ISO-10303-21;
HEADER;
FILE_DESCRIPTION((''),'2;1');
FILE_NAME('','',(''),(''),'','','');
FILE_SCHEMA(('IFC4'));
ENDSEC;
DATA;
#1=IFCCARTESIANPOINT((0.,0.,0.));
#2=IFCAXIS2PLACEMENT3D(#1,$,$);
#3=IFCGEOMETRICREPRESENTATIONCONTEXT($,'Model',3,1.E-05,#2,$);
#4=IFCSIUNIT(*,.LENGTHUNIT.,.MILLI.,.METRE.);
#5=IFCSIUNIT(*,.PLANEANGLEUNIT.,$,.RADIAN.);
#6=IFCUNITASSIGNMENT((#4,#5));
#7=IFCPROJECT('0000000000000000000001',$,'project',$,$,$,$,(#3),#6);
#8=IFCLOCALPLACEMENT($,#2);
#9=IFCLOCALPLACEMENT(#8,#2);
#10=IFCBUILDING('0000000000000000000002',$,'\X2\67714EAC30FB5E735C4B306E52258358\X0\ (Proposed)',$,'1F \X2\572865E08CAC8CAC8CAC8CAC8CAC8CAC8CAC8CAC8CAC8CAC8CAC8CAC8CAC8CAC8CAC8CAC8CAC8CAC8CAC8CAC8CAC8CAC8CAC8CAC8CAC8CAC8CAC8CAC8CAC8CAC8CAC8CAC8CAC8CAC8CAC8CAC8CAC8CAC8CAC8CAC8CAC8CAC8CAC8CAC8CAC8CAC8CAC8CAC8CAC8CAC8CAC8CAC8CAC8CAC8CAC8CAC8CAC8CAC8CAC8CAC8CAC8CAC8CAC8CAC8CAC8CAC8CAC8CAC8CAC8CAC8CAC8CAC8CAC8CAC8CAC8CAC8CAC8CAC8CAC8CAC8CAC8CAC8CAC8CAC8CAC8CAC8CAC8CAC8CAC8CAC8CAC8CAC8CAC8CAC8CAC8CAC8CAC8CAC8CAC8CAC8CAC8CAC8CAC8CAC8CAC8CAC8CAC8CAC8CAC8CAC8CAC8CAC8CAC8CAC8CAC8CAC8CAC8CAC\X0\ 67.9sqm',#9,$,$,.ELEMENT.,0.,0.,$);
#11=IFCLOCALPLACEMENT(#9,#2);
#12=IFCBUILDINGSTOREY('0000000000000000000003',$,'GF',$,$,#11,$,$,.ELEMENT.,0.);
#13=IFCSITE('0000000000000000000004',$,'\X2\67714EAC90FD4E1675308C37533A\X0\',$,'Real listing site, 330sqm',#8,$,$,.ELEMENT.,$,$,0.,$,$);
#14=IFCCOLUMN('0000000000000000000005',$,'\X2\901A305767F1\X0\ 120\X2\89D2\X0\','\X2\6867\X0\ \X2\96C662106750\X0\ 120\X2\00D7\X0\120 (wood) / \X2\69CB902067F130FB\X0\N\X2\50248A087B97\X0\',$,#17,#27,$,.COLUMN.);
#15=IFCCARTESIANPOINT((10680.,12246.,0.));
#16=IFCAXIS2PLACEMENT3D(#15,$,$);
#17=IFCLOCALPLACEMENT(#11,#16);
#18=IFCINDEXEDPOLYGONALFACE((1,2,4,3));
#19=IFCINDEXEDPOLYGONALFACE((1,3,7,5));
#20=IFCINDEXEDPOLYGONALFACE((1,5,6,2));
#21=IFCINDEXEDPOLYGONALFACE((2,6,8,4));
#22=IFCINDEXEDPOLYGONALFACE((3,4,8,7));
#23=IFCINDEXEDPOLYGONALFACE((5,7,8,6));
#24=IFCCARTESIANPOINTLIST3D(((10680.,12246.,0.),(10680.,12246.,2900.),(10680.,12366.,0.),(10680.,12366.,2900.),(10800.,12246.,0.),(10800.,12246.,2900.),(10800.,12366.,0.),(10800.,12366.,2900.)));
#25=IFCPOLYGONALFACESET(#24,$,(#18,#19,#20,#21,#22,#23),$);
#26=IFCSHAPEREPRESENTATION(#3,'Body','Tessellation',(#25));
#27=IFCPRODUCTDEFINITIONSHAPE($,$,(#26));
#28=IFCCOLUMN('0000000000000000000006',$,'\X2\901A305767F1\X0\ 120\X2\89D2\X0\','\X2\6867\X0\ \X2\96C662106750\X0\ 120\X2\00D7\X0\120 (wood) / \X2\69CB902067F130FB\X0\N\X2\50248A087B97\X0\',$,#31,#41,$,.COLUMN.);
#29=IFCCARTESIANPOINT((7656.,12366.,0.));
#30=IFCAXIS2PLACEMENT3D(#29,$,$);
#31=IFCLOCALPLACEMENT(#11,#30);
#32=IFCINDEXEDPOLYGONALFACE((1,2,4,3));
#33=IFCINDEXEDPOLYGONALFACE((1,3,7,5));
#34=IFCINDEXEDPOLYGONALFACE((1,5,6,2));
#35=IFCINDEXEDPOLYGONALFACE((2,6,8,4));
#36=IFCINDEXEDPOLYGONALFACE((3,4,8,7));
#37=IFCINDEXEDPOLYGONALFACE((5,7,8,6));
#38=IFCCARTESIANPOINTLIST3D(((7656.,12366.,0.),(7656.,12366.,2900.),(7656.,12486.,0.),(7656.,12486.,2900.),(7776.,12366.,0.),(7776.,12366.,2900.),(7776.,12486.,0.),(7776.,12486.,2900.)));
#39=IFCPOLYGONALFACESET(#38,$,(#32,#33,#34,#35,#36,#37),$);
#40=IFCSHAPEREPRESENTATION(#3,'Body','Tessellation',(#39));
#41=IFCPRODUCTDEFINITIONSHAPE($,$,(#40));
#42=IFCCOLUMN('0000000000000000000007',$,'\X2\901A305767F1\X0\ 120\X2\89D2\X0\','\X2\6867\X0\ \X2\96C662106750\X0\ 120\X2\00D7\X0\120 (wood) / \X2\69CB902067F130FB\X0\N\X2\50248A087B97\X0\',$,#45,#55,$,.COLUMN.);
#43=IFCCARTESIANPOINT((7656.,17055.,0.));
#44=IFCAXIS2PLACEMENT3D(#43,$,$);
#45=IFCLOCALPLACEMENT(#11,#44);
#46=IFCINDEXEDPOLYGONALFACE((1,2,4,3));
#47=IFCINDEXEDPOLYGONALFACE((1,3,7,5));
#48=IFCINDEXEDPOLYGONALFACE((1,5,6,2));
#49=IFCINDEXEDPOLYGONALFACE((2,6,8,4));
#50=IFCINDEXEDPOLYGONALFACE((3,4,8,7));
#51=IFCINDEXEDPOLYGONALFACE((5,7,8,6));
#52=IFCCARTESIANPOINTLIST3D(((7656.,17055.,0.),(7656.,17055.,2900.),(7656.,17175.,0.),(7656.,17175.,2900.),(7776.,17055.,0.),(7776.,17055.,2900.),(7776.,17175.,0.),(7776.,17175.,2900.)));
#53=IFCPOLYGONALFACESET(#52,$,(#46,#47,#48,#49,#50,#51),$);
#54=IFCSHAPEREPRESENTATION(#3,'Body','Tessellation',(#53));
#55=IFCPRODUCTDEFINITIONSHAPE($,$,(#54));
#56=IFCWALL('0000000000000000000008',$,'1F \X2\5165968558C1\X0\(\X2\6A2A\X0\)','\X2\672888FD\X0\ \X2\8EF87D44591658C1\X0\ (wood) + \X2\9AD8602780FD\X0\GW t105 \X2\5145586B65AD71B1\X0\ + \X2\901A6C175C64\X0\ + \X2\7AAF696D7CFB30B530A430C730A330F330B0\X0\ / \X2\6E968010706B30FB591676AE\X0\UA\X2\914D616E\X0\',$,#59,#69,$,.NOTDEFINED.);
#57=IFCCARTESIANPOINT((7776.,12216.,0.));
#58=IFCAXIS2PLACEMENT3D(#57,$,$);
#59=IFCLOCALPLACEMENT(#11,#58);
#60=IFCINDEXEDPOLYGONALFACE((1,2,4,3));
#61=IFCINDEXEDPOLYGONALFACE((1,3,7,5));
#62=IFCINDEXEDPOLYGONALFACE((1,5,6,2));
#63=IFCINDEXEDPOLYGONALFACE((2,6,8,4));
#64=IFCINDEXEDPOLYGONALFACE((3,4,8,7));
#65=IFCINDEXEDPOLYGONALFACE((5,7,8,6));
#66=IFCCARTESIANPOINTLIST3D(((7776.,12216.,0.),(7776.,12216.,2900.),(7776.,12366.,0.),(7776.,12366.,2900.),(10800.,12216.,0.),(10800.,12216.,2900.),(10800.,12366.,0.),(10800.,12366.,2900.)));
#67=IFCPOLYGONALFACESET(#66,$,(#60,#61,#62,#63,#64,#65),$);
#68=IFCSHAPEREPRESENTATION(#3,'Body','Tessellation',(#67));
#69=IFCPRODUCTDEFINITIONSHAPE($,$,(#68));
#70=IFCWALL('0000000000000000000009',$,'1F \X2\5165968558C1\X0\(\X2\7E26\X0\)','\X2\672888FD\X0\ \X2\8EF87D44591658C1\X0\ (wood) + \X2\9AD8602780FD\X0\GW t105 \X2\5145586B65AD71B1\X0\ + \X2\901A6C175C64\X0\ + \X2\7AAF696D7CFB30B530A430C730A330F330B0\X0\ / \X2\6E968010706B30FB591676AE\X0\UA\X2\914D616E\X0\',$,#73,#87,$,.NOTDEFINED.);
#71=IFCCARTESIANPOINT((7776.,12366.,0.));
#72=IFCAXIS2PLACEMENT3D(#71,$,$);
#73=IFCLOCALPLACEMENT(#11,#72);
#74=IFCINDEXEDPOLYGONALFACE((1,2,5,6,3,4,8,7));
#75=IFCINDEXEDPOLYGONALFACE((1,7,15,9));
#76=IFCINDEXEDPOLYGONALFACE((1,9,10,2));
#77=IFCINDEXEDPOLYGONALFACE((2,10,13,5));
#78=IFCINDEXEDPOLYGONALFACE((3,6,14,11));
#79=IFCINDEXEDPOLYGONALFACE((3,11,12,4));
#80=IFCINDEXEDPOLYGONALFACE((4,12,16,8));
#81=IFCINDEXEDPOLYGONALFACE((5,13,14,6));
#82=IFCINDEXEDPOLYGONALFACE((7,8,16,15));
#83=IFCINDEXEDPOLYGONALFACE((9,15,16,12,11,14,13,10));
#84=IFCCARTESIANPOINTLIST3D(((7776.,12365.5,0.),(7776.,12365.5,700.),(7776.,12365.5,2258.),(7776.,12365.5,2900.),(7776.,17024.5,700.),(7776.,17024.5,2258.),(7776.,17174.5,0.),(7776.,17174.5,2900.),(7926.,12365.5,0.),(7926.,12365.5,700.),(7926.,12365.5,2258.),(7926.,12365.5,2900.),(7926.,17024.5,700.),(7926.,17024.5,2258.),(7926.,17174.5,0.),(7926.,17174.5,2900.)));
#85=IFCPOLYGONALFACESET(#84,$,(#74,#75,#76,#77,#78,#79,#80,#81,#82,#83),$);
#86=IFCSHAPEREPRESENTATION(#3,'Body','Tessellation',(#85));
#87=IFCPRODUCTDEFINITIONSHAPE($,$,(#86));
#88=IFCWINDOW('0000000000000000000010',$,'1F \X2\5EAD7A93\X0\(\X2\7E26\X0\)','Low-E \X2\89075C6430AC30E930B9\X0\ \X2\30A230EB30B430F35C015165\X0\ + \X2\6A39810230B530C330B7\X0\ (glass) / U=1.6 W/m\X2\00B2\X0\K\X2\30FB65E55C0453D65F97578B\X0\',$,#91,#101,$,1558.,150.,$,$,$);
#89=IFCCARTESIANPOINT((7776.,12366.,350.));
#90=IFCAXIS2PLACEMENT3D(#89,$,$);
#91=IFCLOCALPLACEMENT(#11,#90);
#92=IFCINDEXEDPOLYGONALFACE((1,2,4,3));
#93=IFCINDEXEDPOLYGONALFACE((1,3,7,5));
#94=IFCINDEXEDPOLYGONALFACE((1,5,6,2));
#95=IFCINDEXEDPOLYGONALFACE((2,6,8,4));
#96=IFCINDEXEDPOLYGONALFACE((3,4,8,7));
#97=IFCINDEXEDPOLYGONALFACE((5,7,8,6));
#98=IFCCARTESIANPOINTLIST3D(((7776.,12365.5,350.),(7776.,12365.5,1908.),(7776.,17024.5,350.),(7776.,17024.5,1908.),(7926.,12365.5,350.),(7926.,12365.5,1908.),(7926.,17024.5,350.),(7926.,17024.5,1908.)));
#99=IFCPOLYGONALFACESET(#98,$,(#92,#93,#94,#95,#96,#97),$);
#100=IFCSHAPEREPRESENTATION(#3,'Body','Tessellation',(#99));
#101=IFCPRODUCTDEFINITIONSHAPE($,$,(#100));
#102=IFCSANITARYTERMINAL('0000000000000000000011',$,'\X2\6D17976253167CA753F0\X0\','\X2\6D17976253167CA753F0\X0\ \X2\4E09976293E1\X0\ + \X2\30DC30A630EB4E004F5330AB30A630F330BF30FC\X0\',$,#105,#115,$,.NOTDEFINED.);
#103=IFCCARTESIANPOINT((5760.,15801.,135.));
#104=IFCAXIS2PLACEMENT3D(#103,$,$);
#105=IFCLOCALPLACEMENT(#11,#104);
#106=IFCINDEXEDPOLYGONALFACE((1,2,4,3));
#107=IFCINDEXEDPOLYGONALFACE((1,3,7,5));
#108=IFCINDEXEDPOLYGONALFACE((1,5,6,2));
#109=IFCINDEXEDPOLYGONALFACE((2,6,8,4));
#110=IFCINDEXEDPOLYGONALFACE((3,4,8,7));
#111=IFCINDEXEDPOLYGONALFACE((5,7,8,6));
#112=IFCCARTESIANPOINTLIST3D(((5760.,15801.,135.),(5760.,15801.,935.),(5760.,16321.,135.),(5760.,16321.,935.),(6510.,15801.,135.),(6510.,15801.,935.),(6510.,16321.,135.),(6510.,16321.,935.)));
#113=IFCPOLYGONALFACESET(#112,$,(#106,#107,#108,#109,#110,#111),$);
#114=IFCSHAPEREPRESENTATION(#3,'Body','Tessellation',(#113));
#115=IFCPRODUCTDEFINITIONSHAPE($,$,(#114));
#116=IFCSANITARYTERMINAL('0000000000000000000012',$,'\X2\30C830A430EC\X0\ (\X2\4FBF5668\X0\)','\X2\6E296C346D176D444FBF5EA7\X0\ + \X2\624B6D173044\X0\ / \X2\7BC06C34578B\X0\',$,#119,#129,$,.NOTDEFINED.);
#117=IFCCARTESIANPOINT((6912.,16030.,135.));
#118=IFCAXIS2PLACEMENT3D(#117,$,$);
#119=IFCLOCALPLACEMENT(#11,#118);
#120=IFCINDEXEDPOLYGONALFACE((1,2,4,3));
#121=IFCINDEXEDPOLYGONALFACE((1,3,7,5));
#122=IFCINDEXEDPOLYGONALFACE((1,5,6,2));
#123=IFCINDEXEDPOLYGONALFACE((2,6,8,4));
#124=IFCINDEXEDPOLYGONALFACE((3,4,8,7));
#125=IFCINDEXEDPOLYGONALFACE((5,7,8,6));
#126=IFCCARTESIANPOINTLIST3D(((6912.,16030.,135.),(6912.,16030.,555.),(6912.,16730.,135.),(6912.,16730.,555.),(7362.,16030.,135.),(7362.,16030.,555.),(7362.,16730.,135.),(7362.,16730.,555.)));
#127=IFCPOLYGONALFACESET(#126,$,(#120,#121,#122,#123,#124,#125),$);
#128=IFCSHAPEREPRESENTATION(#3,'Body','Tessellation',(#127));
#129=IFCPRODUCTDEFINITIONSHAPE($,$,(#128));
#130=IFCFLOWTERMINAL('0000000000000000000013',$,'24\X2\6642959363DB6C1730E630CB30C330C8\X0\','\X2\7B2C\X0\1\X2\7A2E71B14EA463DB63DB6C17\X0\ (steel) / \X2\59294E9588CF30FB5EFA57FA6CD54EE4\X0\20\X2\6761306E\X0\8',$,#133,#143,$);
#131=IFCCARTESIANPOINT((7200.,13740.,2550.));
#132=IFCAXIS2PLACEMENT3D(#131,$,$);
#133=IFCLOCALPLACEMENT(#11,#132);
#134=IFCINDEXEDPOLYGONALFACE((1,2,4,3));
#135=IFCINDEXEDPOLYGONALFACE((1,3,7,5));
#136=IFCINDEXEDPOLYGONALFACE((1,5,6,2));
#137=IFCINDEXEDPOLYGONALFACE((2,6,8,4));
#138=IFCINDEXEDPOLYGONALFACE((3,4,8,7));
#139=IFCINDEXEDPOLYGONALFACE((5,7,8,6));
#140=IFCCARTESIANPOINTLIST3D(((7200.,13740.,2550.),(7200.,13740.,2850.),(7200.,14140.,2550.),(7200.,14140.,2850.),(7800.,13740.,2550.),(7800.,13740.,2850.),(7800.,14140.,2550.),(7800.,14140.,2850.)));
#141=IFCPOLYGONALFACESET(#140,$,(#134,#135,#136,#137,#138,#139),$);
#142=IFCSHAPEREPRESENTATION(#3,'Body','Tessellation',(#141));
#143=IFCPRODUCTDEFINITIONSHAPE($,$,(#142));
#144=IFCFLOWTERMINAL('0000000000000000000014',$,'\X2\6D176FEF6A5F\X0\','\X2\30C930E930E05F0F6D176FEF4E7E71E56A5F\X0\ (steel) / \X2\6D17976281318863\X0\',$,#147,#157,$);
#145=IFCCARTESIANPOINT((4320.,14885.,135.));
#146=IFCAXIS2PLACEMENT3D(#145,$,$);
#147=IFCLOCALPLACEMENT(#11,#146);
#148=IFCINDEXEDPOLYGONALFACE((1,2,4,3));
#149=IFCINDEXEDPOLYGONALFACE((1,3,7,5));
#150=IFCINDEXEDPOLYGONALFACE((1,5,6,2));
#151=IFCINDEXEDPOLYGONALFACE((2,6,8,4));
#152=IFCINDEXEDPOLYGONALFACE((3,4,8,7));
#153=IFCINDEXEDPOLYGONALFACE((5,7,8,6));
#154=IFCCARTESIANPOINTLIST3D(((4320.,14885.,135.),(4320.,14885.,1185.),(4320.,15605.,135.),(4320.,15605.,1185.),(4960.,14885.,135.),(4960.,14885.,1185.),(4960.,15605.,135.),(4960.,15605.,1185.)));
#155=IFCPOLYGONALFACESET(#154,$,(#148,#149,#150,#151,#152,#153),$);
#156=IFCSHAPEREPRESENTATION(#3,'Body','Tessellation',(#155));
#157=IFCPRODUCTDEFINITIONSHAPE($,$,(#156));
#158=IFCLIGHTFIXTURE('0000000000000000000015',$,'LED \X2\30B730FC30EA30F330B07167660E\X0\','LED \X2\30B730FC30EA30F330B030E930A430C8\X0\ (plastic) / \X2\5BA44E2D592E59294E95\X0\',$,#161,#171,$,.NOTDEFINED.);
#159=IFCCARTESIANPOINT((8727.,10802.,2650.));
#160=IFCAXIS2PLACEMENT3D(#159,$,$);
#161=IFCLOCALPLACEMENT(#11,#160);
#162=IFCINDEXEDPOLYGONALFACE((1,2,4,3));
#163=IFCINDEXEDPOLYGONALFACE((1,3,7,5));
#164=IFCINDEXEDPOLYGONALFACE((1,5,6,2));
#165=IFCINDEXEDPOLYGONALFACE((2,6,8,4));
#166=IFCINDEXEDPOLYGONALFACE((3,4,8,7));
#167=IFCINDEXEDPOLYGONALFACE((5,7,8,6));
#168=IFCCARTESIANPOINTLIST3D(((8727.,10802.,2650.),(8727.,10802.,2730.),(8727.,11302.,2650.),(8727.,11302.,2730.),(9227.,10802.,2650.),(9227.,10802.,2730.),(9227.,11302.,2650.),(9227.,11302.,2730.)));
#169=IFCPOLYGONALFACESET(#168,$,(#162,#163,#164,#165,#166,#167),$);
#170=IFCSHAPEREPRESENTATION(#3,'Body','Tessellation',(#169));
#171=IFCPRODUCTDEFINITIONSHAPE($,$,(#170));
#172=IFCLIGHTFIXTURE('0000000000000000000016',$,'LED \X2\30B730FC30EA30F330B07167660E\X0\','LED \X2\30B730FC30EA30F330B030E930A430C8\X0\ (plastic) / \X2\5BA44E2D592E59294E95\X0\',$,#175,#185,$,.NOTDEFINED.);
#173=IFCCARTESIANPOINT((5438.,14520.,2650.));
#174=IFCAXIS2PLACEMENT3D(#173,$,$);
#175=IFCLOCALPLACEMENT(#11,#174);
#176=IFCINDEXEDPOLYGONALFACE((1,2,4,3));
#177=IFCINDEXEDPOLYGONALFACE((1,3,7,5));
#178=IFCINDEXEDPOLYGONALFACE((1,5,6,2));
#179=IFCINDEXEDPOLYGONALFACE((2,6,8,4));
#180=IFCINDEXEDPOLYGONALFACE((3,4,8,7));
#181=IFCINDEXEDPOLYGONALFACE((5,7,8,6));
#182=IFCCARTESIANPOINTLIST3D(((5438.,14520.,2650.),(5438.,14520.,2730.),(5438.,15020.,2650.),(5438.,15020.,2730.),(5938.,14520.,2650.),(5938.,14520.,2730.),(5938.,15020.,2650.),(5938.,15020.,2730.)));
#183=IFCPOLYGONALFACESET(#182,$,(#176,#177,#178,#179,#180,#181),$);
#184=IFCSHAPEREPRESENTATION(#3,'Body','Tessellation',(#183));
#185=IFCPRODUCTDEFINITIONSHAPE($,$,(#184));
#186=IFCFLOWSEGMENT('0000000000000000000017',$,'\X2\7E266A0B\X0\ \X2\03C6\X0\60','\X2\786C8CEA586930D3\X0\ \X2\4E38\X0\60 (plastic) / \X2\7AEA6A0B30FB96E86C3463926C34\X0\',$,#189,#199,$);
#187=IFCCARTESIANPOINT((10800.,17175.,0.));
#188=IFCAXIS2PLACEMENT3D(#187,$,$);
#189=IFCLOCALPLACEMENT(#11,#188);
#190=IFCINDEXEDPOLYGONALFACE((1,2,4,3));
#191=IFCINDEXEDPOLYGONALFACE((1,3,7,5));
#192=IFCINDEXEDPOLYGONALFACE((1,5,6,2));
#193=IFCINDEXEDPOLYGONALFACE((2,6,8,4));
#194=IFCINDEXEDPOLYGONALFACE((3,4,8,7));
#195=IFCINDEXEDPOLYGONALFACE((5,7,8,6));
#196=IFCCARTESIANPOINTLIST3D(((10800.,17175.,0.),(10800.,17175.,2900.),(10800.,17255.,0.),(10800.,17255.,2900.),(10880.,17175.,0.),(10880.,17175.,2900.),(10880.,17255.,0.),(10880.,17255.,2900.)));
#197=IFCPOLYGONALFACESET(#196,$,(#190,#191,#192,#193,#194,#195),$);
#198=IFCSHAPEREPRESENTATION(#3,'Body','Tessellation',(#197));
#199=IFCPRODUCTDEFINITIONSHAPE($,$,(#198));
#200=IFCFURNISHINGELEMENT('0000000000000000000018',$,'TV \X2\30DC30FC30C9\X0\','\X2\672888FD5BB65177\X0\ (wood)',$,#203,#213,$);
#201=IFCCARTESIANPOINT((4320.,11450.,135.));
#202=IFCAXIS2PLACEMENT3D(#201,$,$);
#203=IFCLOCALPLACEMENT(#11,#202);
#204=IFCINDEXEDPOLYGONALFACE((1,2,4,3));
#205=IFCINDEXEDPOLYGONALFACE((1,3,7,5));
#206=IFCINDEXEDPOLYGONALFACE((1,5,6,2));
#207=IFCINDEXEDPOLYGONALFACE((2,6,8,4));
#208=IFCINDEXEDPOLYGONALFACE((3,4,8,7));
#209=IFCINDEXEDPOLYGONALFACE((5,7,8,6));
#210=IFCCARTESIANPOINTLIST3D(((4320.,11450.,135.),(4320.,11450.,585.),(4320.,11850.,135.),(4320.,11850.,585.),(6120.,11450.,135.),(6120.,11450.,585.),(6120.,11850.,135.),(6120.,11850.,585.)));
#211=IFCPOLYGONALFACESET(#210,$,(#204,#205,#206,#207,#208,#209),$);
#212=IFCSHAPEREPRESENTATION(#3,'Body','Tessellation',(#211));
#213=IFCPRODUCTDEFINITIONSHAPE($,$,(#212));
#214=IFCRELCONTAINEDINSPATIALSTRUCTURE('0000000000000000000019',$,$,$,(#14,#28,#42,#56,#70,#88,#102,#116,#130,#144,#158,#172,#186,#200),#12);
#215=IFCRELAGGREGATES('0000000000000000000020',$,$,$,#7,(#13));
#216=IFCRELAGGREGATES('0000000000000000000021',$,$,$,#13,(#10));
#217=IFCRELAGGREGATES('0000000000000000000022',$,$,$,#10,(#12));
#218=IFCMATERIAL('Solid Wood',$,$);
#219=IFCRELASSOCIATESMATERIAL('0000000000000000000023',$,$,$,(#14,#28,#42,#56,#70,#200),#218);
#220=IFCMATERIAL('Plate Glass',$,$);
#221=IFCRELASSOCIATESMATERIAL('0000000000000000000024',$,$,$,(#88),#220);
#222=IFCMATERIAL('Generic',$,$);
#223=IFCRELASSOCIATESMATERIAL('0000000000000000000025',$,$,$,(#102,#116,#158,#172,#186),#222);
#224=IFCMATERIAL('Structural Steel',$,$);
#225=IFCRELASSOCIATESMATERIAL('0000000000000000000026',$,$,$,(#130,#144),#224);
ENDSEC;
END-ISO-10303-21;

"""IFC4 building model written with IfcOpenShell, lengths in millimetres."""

from ifc_helpers import new_model, si_unit, frame, frame_2d, origin, place, context, project, spatial, rectangle, extrude, material, element, fill, save


model = new_model("IFC4")

# Units and contexts
model_context = context("Model", 3, precision=1e-05, world=origin())
ifc_project = project(units=[si_unit("LENGTHUNIT", "METRE", prefix="MILLI"), si_unit("PLANEANGLEUNIT", "RADIAN")], contexts=[model_context])

# Site, building, storey
site_placement = place(None, origin())
site = spatial("IfcSite", under=ifc_project, at=site_placement, Name="東京都世田谷区", ObjectType="Real listing site, 330sqm", CompositionType="ELEMENT", RefElevation=0.0)
building_placement = place(site_placement, origin())
building = spatial("IfcBuilding", under=site, at=building_placement, Name="東京・平屋の別荘 (Proposed)", ObjectType="1F 在无責責責責責責責責責責責責責責責責責責責責責責責責責責責責責責責責責責責責責責責責責責責責責責責責責責責責責責責責責責責責責責責責責責責責責責責責責責責責責責責責責責責責責責責責責責責責責責責責責責責責責責責責責責責責責責責責責責責責責責 67.9sqm", CompositionType="ELEMENT", ElevationOfRefHeight=0.0, ElevationOfTerrain=0.0)
storey_placement = place(building_placement, origin())
storey = spatial("IfcBuildingStorey", under=building, at=storey_placement, Name="GF", CompositionType="ELEMENT", Elevation=0.0)

# Columns
ifc_material_1 = material(Name="Solid Wood")
column_1_placement = place(storey_placement, frame((10680.0, 12246.0, 0.0)))
element("IfcColumn", 1, at=column_1_placement, inside=storey, material=ifc_material_1, Name="通し柱 120角", Description="桧 集成材 120×120 (wood) / 構造柱・N値計算", PredefinedType="COLUMN", context=model_context, shape_type="SweptSolid", body=[
    extrude(rectangle(XDim=120.0, YDim=120.0, at=frame_2d((60.0, 60.0))), frame((10680.0, 12246.0, 0.0)), (0.0, 0.0, 1.0), 2900.0),
])
column_2_placement = place(storey_placement, frame((7656.0, 12366.0, 0.0)))
element("IfcColumn", 2, at=column_2_placement, inside=storey, material=ifc_material_1, Name="通し柱 120角", Description="桧 集成材 120×120 (wood) / 構造柱・N値計算", PredefinedType="COLUMN", context=model_context, shape_type="SweptSolid", body=[
    extrude(rectangle(XDim=120.0, YDim=120.0, at=frame_2d((60.0, 60.0))), frame((7656.0, 12366.0, 0.0)), (0.0, 0.0, 1.0), 2900.0),
])
column_3_placement = place(storey_placement, frame((7656.0, 17055.0, 0.0)))
element("IfcColumn", 3, at=column_3_placement, inside=storey, material=ifc_material_1, Name="通し柱 120角", Description="桧 集成材 120×120 (wood) / 構造柱・N値計算", PredefinedType="COLUMN", context=model_context, shape_type="SweptSolid", body=[
    extrude(rectangle(XDim=120.0, YDim=120.0, at=frame_2d((60.0, 60.0))), frame((7656.0, 17055.0, 0.0)), (0.0, 0.0, 1.0), 2900.0),
])

# Wall
wall_1_placement = place(storey_placement, frame((7776.0, 12216.0, 0.0)))
element("IfcWall", 4, at=wall_1_placement, inside=storey, material=ifc_material_1, Name="1F 入隅壁(横)", Description="木製 軸組外壁 (wood) + 高性能GW t105 充填断熱 + 通気層 + 窯業系サイディング / 準耐火・外皮UA配慮", PredefinedType="NOTDEFINED", context=model_context, shape_type="SweptSolid", body=[
    extrude(rectangle(XDim=3024.0, YDim=150.0, at=frame_2d((1512.0, 75.0))), frame((7776.0, 12216.0, 0.0)), (0.0, 0.0, 1.0), 2900.0),
])

# Wall, opening, window
wall_2_placement = place(storey_placement, frame((7776.0, 12366.0, 0.0)))
wall_2 = element("IfcWall", 5, at=wall_2_placement, inside=storey, material=ifc_material_1, Name="1F 入隅壁(縦)", Description="木製 軸組外壁 (wood) + 高性能GW t105 充填断熱 + 通気層 + 窯業系サイディング / 準耐火・外皮UA配慮", PredefinedType="NOTDEFINED", context=model_context, shape_type="SweptSolid", body=[
    extrude(rectangle(XDim=150.0, YDim=4809.0, at=frame_2d((75.0, 2404.0))), frame((7776.0, 12366.0, 0.0)), (0.0, 0.0, 1.0), 2900.0),
])
opening_placement = place(storey_placement, frame((7776.0, 12366.0, 350.0)))
opening = element("IfcOpeningElement", 6, at=opening_placement, cuts=wall_2, PredefinedType="NOTDEFINED", context=model_context, shape_type="SweptSolid", body=[
    extrude(rectangle(XDim=150.0, YDim=4659.0, at=frame_2d((75.0, 2329.0))), frame((7776.0, 12366.0, 350.0)), (0.0, 0.0, 1.0), 1558.0),
])
ifc_material_2 = material(Name="Plate Glass")
window_placement = place(storey_placement, frame((7776.0, 12366.0, 350.0)))
window = element("IfcWindow", 7, at=window_placement, inside=storey, material=ifc_material_2, Name="1F 庭窓(縦)", Description="Low-E 複層ガラス アルゴン封入 + 樹脂サッシ (glass) / U=1.6 W/m²K・日射取得型", OverallHeight=1558.0, OverallWidth=150.0, context=model_context, shape_type="SweptSolid", body=[
    extrude(rectangle(XDim=150.0, YDim=4659.0, at=frame_2d((75.0, 2329.0))), frame((7776.0, 12366.0, 350.0)), (0.0, 0.0, 1.0), 1558.0),
])
fill(opening, window)

# Sanitary terminals
ifc_material_3 = material(Name="Generic")
sanitary_terminal_1_placement = place(storey_placement, frame((5760.0, 15801.0, 135.0)))
element("IfcSanitaryTerminal", 8, at=sanitary_terminal_1_placement, inside=storey, material=ifc_material_3, Name="洗面化粧台", Description="洗面化粧台 三面鏡 + ボウル一体カウンター", PredefinedType="NOTDEFINED", context=model_context, shape_type="SweptSolid", body=[
    extrude(rectangle(XDim=750.0, YDim=520.0, at=frame_2d((375.0, 260.0))), frame((5760.0, 15801.0, 135.0)), (0.0, 0.0, 1.0), 800.0),
])
sanitary_terminal_2_placement = place(storey_placement, frame((6912.0, 16030.0, 135.0)))
element("IfcSanitaryTerminal", 9, at=sanitary_terminal_2_placement, inside=storey, material=ifc_material_3, Name="トイレ (便器)", Description="温水洗浄便座 + 手洗い / 節水型", PredefinedType="NOTDEFINED", context=model_context, shape_type="SweptSolid", body=[
    extrude(rectangle(XDim=450.0, YDim=700.0, at=frame_2d((225.0, 350.0))), frame((6912.0, 16030.0, 135.0)), (0.0, 0.0, 1.0), 420.0),
])

# Flow terminals
ifc_material_4 = material(Name="Structural Steel")
flow_terminal_1_placement = place(storey_placement, frame((7200.0, 13740.0, 2550.0)))
element("IfcFlowTerminal", 10, at=flow_terminal_1_placement, inside=storey, material=ifc_material_4, Name="24時間換気ユニット", Description="第1種熱交換換気 (steel) / 天井裏・建基法令20条の8", context=model_context, shape_type="SweptSolid", body=[
    extrude(rectangle(XDim=600.0, YDim=400.0, at=frame_2d((300.0, 200.0))), frame((7200.0, 13740.0, 2550.0)), (0.0, 0.0, 1.0), 300.0),
])
flow_terminal_2_placement = place(storey_placement, frame((4320.0, 14885.0, 135.0)))
element("IfcFlowTerminal", 11, at=flow_terminal_2_placement, inside=storey, material=ifc_material_4, Name="洗濯機", Description="ドラム式洗濯乾燥機 (steel) / 洗面脱衣", context=model_context, shape_type="SweptSolid", body=[
    extrude(rectangle(XDim=640.0, YDim=720.0, at=frame_2d((320.0, 360.0))), frame((4320.0, 14885.0, 135.0)), (0.0, 0.0, 1.0), 1050.0),
])

# Light fixtures
light_fixture_1_placement = place(storey_placement, frame((8727.0, 10802.0, 2650.0)))
element("IfcLightFixture", 12, at=light_fixture_1_placement, inside=storey, material=ifc_material_3, Name="LED シーリング照明", Description="LED シーリングライト (plastic) / 室中央天井", PredefinedType="NOTDEFINED", context=model_context, shape_type="SweptSolid", body=[
    extrude(rectangle(XDim=500.0, YDim=500.0, at=frame_2d((250.0, 250.0))), frame((8727.0, 10802.0, 2650.0)), (0.0, 0.0, 1.0), 80.0),
])
light_fixture_2_placement = place(storey_placement, frame((5438.0, 14520.0, 2650.0)))
element("IfcLightFixture", 13, at=light_fixture_2_placement, inside=storey, material=ifc_material_3, Name="LED シーリング照明", Description="LED シーリングライト (plastic) / 室中央天井", PredefinedType="NOTDEFINED", context=model_context, shape_type="SweptSolid", body=[
    extrude(rectangle(XDim=500.0, YDim=500.0, at=frame_2d((250.0, 250.0))), frame((5438.0, 14520.0, 2650.0)), (0.0, 0.0, 1.0), 80.0),
])

# Flow segment
flow_segment_placement = place(storey_placement, frame((10800.0, 17175.0, 0.0)))
element("IfcFlowSegment", 14, at=flow_segment_placement, inside=storey, material=ifc_material_3, Name="縦樋 φ60", Description="硬質塩ビ 丸60 (plastic) / 竪樋・雨水排水", context=model_context, shape_type="SweptSolid", body=[
    extrude(rectangle(XDim=80.0, YDim=80.0, at=frame_2d((40.0, 40.0))), frame((10800.0, 17175.0, 0.0)), (0.0, 0.0, 1.0), 2900.0),
])

# Furnishing element
furnishing_placement = place(storey_placement, frame((4320.0, 11450.0, 135.0)))
element("IfcFurnishingElement", 15, at=furnishing_placement, inside=storey, material=ifc_material_1, Name="TV ボード", Description="木製家具 (wood)", context=model_context, shape_type="SweptSolid", body=[
    extrude(rectangle(XDim=1800.0, YDim=400.0, at=frame_2d((900.0, 200.0))), frame((4320.0, 11450.0, 135.0)), (0.0, 0.0, 1.0), 450.0),
])

save(model, "model.ifc")
